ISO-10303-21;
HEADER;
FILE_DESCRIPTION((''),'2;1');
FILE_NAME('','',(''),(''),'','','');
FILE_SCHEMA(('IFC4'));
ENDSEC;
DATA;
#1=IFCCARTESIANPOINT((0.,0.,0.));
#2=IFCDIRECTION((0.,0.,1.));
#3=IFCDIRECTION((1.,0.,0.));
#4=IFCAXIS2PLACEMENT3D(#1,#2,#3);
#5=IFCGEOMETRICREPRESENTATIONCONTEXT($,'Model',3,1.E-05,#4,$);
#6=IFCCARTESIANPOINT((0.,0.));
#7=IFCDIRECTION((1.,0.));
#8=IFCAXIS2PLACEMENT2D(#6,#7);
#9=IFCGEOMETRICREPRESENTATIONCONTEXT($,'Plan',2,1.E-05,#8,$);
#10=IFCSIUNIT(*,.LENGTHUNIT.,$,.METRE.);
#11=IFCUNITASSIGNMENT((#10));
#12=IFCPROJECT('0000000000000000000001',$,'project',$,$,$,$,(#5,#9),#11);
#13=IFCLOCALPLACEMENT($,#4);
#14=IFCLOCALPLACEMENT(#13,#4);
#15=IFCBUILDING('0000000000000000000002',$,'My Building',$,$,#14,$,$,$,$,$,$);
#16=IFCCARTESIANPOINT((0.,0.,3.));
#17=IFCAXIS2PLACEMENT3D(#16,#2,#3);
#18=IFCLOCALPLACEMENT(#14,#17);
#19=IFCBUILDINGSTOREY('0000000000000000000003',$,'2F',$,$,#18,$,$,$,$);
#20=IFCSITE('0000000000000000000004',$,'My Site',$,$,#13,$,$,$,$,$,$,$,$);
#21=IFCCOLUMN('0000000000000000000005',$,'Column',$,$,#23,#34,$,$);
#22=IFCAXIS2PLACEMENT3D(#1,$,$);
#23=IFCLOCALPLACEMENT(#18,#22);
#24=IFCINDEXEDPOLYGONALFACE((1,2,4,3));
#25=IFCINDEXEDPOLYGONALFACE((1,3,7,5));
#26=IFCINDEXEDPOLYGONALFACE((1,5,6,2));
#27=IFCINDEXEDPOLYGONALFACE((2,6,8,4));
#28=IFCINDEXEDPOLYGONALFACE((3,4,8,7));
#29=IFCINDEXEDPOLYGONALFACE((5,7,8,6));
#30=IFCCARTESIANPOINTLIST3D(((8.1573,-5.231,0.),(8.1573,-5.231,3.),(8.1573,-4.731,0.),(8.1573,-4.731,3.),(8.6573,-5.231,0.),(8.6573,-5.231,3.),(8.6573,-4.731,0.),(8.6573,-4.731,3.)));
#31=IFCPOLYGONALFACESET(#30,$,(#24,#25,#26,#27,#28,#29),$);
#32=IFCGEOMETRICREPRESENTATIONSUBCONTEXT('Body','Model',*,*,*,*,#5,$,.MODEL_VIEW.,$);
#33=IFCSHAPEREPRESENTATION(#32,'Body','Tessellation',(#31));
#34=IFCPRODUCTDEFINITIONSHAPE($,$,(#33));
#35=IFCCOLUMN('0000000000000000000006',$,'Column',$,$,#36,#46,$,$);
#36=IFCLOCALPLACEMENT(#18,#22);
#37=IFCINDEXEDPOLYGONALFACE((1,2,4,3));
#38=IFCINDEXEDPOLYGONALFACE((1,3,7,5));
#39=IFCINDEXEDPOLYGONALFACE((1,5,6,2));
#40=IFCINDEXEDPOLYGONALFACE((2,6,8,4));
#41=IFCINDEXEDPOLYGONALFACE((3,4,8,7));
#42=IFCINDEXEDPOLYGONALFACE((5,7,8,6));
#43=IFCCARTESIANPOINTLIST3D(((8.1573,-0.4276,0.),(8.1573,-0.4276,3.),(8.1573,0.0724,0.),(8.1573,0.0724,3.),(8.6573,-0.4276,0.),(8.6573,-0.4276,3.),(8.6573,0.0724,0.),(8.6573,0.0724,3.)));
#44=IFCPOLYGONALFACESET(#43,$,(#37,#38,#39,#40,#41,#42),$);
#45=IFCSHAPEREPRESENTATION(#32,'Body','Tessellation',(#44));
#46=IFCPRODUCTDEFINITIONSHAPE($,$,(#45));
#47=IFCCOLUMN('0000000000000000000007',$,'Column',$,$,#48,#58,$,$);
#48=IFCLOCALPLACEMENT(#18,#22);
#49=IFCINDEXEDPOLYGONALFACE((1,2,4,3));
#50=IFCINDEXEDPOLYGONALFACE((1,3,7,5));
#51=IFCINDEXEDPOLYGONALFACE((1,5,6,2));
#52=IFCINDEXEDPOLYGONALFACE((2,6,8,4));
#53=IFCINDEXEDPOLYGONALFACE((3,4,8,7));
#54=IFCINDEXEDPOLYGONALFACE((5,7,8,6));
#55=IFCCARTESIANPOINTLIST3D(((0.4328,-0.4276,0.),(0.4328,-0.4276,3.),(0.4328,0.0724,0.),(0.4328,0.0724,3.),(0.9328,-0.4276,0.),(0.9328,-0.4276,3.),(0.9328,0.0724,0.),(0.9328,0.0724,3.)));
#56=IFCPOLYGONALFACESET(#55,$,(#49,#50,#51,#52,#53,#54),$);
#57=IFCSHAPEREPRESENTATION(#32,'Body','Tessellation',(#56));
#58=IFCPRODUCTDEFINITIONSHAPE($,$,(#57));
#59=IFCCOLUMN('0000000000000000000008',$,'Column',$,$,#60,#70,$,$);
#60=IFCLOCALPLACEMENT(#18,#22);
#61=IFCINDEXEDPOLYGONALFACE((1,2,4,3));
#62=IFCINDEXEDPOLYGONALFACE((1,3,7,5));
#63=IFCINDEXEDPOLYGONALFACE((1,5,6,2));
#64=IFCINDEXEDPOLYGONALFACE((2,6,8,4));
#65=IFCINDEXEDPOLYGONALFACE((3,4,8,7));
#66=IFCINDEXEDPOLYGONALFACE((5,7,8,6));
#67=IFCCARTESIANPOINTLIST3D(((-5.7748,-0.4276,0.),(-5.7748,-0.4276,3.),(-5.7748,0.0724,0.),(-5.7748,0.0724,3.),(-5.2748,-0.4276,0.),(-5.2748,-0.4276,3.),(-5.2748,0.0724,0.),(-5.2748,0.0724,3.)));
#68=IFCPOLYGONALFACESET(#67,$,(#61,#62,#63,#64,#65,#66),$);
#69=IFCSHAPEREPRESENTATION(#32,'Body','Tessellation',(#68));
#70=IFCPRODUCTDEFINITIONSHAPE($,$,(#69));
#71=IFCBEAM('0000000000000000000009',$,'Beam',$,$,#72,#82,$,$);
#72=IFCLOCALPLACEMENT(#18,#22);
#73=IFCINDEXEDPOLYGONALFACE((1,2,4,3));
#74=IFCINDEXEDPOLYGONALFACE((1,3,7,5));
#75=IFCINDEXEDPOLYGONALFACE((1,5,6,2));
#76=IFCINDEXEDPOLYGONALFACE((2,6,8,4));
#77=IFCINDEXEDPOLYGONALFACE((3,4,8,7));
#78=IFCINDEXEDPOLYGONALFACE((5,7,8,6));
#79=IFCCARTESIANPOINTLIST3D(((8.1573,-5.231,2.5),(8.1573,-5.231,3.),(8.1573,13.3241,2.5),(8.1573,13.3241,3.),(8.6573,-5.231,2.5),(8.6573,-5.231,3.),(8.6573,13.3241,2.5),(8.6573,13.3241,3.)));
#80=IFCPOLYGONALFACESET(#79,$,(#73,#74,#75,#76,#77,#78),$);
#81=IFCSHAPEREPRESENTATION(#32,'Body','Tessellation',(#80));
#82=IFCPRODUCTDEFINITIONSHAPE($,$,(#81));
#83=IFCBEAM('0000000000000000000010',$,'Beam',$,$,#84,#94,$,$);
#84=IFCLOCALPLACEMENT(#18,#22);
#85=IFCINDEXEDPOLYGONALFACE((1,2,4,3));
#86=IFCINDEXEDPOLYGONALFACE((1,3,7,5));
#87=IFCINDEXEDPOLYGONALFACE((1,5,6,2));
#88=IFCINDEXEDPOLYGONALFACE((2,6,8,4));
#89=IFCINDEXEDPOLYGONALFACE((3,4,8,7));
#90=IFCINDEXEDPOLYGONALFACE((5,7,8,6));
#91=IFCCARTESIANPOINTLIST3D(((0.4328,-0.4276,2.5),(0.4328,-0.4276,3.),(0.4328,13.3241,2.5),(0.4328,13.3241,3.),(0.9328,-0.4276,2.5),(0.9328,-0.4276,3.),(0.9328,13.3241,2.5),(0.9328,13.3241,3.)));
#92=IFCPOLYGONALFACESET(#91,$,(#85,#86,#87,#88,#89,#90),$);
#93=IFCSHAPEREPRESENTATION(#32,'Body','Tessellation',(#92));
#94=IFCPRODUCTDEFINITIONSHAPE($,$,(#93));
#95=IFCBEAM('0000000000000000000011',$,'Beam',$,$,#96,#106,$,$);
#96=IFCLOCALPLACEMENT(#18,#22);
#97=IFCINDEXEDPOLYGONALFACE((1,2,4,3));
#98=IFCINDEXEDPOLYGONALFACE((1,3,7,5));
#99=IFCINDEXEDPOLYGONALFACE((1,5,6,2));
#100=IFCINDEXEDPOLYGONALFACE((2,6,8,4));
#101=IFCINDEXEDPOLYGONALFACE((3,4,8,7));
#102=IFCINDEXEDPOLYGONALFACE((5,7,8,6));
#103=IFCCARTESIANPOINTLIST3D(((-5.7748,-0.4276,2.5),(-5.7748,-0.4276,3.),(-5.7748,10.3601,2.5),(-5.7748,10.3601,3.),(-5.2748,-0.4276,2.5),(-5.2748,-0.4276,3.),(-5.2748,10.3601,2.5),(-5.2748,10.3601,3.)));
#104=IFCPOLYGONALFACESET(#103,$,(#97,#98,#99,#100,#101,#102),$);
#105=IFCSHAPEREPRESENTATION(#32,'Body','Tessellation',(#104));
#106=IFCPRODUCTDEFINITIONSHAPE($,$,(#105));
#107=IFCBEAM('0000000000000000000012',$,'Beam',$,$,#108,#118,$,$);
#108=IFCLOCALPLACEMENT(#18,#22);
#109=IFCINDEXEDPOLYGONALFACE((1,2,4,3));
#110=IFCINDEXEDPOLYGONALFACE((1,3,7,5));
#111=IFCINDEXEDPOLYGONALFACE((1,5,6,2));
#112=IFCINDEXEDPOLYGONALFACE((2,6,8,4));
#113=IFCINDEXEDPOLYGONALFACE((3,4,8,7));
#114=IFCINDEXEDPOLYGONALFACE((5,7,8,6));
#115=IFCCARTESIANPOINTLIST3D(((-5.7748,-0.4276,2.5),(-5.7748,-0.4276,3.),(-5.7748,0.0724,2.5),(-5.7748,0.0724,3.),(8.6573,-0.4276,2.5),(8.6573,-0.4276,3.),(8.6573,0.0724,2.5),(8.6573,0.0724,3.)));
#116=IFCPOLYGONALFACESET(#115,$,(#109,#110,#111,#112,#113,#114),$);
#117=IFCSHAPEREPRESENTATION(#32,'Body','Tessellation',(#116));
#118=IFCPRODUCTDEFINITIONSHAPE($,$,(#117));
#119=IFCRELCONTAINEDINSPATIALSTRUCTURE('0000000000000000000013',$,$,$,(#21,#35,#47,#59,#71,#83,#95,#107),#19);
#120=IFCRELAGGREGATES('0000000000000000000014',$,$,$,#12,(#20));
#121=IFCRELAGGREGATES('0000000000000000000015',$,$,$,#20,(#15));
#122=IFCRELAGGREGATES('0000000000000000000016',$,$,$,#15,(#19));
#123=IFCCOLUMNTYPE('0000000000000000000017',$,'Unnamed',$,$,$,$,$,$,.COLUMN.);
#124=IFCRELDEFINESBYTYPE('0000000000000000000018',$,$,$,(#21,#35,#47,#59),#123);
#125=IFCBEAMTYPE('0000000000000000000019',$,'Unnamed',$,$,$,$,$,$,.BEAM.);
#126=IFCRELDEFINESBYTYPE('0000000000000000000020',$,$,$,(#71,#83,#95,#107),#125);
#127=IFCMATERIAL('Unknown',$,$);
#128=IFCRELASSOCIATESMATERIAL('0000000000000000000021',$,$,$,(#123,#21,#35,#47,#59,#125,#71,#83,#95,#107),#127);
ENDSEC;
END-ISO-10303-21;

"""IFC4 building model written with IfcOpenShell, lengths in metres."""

from ifc_helpers import new_model, si_unit, frame, origin_with_axes, origin_2d_with_axis, place, context, subcontext, project, spatial, rectangle, extrude, material, material_profile, profile_set, profile_usage, type_object, element, save


model = new_model("IFC4")

# Units and contexts
model_context = context("Model", 3, precision=1e-05, world=origin_with_axes())
plan_context = context("Plan", 2, precision=1e-05, world=origin_2d_with_axis())
body_context_1 = subcontext(model_context, "Body", "Model", "MODEL_VIEW")
ifc_project = project(units=[si_unit("LENGTHUNIT", "METRE")], contexts=[model_context, plan_context])

# Site, building, storey
site_placement = place(None, origin_with_axes())
site = spatial("IfcSite", under=ifc_project, at=site_placement, Name="My Site")
building_placement = place(site_placement, origin_with_axes())
building = spatial("IfcBuilding", under=site, at=building_placement, Name="My Building")
storey_placement = place(building_placement, frame((0.0, 0.0, 3.0), z_axis=(0.0, 0.0, 1.0), x_axis=(1.0, 0.0, 0.0)))
storey = spatial("IfcBuildingStorey", under=building, at=storey_placement, Name="2F")

# Columns
ifc_material = material(Name="Unknown")
ifc_material_profile_1 = material_profile(ifc_material, rectangle(XDim=0.5, YDim=0.5))
ifc_profile_set_1 = profile_set([ifc_material_profile_1])
ifc_profile_usage_1 = profile_usage(ifc_profile_set_1, cardinal=1)
column_type = type_object("IfcColumnType", Name="Unnamed", PredefinedType="COLUMN", material=ifc_profile_set_1)
column_1_placement = place(storey_placement, frame((8.6573, -5.231, 0.0), z_axis=(0.0, 0.0, 1.0), x_axis=(1.0, 0.0, 0.0)))
element("IfcColumn", 1, at=column_1_placement, inside=storey, type_object=column_type, material=ifc_profile_usage_1, Name="Column", context=body_context_1, shape_type="SweptSolid", body=[
    extrude(rectangle(XDim=0.5, YDim=0.5), frame((-0.25, 0.25, 0.0), z_axis=(0.0, 0.0, 1.0), x_axis=(1.0, 0.0, 0.0)), (0.0, 0.0, 1.0), 3.0),
])
ifc_profile_usage_2 = profile_usage(ifc_profile_set_1, cardinal=1)
column_2_placement = place(storey_placement, frame((8.6573, -0.4276, 0.0), z_axis=(0.0, 0.0, 1.0), x_axis=(1.0, 0.0, 0.0)))
element("IfcColumn", 2, at=column_2_placement, inside=storey, type_object=column_type, material=ifc_profile_usage_2, Name="Column", context=body_context_1, shape_type="SweptSolid", body=[
    extrude(rectangle(XDim=0.5, YDim=0.5), frame((-0.25, 0.25, 0.0), z_axis=(0.0, 0.0, 1.0), x_axis=(1.0, 0.0, 0.0)), (0.0, 0.0, 1.0), 3.0),
])
ifc_profile_usage_3 = profile_usage(ifc_profile_set_1, cardinal=1)
column_3_placement = place(storey_placement, frame((0.9328, -0.4276, 0.0), z_axis=(0.0, 0.0, 1.0), x_axis=(1.0, 0.0, 0.0)))
element("IfcColumn", 3, at=column_3_placement, inside=storey, type_object=column_type, material=ifc_profile_usage_3, Name="Column", context=body_context_1, shape_type="SweptSolid", body=[
    extrude(rectangle(XDim=0.5, YDim=0.5), frame((-0.25, 0.25, 0.0), z_axis=(0.0, 0.0, 1.0), x_axis=(1.0, 0.0, 0.0)), (0.0, 0.0, 1.0), 3.0),
])
ifc_profile_usage_4 = profile_usage(ifc_profile_set_1, cardinal=1)
column_4_placement = place(storey_placement, frame((-5.2748, -0.4276, 0.0), z_axis=(0.0, 0.0, 1.0), x_axis=(1.0, 0.0, 0.0)))
element("IfcColumn", 4, at=column_4_placement, inside=storey, type_object=column_type, material=ifc_profile_usage_4, Name="Column", context=body_context_1, shape_type="SweptSolid", body=[
    extrude(rectangle(XDim=0.5, YDim=0.5), frame((-0.25, 0.25, 0.0), z_axis=(0.0, 0.0, 1.0), x_axis=(1.0, 0.0, 0.0)), (0.0, 0.0, 1.0), 3.0),
])

# Beams
ifc_material_profile_2 = material_profile(ifc_material, rectangle(XDim=0.5, YDim=0.5))
ifc_profile_set_2 = profile_set([ifc_material_profile_2])
ifc_profile_usage_5 = profile_usage(ifc_profile_set_2, cardinal=9)
beam_type = type_object("IfcBeamType", Name="Unnamed", PredefinedType="BEAM", material=ifc_profile_set_2)
beam_1_placement = place(storey_placement, frame((8.6573, -5.231, 3.0), z_axis=(0.0, 1.0, 0.0), x_axis=(-1.0, 0.0, 0.0)))
element("IfcBeam", 5, at=beam_1_placement, inside=storey, type_object=beam_type, material=ifc_profile_usage_5, Name="Beam", context=body_context_1, shape_type="SweptSolid", body=[
    extrude(rectangle(XDim=0.5, YDim=0.5), frame((0.25, -0.25, 0.0), z_axis=(0.0, 0.0, 1.0), x_axis=(1.0, 0.0, 0.0)), (0.0, 0.0, 1.0), 18.555),
])
ifc_profile_usage_6 = profile_usage(ifc_profile_set_2, cardinal=9)
beam_2_placement = place(storey_placement, frame((0.9328, -0.4276, 3.0), z_axis=(0.0, 1.0, 0.0), x_axis=(-1.0, 0.0, 0.0)))
element("IfcBeam", 6, at=beam_2_placement, inside=storey, type_object=beam_type, material=ifc_profile_usage_6, Name="Beam", context=body_context_1, shape_type="SweptSolid", body=[
    extrude(rectangle(XDim=0.5, YDim=0.5), frame((0.25, -0.25, 0.0), z_axis=(0.0, 0.0, 1.0), x_axis=(1.0, 0.0, 0.0)), (0.0, 0.0, 1.0), 13.7517),
])
ifc_profile_usage_7 = profile_usage(ifc_profile_set_2, cardinal=9)
beam_3_placement = place(storey_placement, frame((-5.2748, -0.4276, 3.0), z_axis=(0.0, 1.0, 0.0), x_axis=(-1.0, 0.0, 0.0)))
element("IfcBeam", 7, at=beam_3_placement, inside=storey, type_object=beam_type, material=ifc_profile_usage_7, Name="Beam", context=body_context_1, shape_type="SweptSolid", body=[
    extrude(rectangle(XDim=0.5, YDim=0.5), frame((0.25, -0.25, 0.0), z_axis=(0.0, 0.0, 1.0), x_axis=(1.0, 0.0, 0.0)), (0.0, 0.0, 1.0), 10.7877),
])
ifc_profile_usage_8 = profile_usage(ifc_profile_set_2, cardinal=9)
beam_4_placement = place(storey_placement, frame((-5.7748, -0.4276, 3.0), z_axis=(1.0, 0.0, 0.0), x_axis=(0.0, 1.0, 0.0)))
element("IfcBeam", 8, at=beam_4_placement, inside=storey, type_object=beam_type, material=ifc_profile_usage_8, Name="Beam", context=body_context_1, shape_type="SweptSolid", body=[
    extrude(rectangle(XDim=0.5, YDim=0.5), frame((0.25, -0.25, 0.0), z_axis=(0.0, 0.0, 1.0), x_axis=(1.0, 0.0, 0.0)), (0.0, 0.0, 1.0), 14.4321),
])

save(model, "model.ifc")
